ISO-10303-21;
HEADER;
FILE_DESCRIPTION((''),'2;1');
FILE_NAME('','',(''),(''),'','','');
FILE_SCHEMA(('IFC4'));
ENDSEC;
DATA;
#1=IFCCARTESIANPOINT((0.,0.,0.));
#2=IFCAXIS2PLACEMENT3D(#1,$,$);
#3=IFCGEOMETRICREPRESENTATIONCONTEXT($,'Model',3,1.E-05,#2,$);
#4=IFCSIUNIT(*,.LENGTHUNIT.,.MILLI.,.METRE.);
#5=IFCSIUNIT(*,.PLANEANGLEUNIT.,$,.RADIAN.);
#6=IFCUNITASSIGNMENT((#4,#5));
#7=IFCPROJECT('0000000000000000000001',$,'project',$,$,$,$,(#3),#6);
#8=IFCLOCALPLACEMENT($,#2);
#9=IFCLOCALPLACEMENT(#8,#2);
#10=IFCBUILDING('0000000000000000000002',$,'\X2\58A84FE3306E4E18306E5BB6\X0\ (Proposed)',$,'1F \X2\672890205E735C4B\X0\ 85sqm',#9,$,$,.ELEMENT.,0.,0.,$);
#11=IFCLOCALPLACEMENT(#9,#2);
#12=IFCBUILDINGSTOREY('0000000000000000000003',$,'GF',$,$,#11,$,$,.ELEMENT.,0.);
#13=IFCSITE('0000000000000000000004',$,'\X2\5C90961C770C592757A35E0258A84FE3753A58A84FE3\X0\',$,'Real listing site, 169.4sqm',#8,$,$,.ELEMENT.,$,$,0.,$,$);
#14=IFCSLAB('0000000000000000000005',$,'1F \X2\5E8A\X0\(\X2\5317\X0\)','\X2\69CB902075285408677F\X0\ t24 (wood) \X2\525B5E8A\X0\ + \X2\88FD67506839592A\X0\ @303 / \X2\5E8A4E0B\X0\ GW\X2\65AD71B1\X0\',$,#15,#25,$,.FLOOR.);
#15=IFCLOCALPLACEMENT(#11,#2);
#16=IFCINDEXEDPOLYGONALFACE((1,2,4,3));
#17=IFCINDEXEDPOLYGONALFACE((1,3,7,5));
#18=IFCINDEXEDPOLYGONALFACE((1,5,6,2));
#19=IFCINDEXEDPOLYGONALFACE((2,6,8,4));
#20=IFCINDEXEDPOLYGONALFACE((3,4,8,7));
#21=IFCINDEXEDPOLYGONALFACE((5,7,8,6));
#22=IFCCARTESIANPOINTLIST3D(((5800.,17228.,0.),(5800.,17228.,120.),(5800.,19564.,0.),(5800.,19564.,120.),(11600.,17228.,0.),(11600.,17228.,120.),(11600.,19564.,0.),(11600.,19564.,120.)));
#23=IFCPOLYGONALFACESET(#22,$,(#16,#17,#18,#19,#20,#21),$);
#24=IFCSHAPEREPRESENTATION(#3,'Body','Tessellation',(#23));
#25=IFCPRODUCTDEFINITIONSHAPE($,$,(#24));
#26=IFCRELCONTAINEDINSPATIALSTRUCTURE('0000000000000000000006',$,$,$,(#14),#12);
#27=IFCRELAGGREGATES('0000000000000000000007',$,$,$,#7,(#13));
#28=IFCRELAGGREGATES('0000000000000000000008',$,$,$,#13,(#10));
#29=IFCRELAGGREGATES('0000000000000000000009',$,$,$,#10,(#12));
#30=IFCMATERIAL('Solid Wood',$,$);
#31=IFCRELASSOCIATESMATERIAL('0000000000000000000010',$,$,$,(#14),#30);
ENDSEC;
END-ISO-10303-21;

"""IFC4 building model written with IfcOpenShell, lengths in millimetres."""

from ifc_helpers import new_model, si_unit, frame, frame_2d, origin, place, context, project, spatial, rectangle, extrude, material, element, save


model = new_model("IFC4")

# Units and contexts
model_context = context("Model", 3, precision=1e-05, world=origin())
ifc_project = project(units=[si_unit("LENGTHUNIT", "METRE", prefix="MILLI"), si_unit("PLANEANGLEUNIT", "RADIAN")], contexts=[model_context])

# Site, building, storey
site_placement = place(None, origin())
site = spatial("IfcSite", under=ifc_project, at=site_placement, Name="岐阜県大垣市墨俣町墨俣", ObjectType="Real listing site, 169.4sqm", CompositionType="ELEMENT", RefElevation=0.0)
building_placement = place(site_placement, origin())
building = spatial("IfcBuilding", under=site, at=building_placement, Name="墨俣の丘の家 (Proposed)", ObjectType="1F 木造平屋 85sqm", CompositionType="ELEMENT", ElevationOfRefHeight=0.0, ElevationOfTerrain=0.0)
storey_placement = place(building_placement, origin())
storey = spatial("IfcBuildingStorey", under=building, at=storey_placement, Name="GF", CompositionType="ELEMENT", Elevation=0.0)

# Slab
ifc_material_1 = material(Name="Solid Wood")
slab_1_placement = place(storey_placement, frame((2900.0, 8614.0, 0.0)))
element("IfcSlab", 1, at=slab_1_placement, inside=storey, material=ifc_material_1, Name="1F 床(北)", Description="構造用合板 t24 (wood) 剛床 + 製材根太 @303 / 床下 GW断熱", PredefinedType="FLOOR", context=model_context, shape_type="SweptSolid", body=[
    extrude(rectangle(XDim=5800.0, YDim=2336.0, at=frame_2d((2900.0, 1168.0))), frame((2900.0, 8614.0, 0.0)), (0.0, 0.0, 1.0), 120.0),
])

save(model, "model.ifc")
